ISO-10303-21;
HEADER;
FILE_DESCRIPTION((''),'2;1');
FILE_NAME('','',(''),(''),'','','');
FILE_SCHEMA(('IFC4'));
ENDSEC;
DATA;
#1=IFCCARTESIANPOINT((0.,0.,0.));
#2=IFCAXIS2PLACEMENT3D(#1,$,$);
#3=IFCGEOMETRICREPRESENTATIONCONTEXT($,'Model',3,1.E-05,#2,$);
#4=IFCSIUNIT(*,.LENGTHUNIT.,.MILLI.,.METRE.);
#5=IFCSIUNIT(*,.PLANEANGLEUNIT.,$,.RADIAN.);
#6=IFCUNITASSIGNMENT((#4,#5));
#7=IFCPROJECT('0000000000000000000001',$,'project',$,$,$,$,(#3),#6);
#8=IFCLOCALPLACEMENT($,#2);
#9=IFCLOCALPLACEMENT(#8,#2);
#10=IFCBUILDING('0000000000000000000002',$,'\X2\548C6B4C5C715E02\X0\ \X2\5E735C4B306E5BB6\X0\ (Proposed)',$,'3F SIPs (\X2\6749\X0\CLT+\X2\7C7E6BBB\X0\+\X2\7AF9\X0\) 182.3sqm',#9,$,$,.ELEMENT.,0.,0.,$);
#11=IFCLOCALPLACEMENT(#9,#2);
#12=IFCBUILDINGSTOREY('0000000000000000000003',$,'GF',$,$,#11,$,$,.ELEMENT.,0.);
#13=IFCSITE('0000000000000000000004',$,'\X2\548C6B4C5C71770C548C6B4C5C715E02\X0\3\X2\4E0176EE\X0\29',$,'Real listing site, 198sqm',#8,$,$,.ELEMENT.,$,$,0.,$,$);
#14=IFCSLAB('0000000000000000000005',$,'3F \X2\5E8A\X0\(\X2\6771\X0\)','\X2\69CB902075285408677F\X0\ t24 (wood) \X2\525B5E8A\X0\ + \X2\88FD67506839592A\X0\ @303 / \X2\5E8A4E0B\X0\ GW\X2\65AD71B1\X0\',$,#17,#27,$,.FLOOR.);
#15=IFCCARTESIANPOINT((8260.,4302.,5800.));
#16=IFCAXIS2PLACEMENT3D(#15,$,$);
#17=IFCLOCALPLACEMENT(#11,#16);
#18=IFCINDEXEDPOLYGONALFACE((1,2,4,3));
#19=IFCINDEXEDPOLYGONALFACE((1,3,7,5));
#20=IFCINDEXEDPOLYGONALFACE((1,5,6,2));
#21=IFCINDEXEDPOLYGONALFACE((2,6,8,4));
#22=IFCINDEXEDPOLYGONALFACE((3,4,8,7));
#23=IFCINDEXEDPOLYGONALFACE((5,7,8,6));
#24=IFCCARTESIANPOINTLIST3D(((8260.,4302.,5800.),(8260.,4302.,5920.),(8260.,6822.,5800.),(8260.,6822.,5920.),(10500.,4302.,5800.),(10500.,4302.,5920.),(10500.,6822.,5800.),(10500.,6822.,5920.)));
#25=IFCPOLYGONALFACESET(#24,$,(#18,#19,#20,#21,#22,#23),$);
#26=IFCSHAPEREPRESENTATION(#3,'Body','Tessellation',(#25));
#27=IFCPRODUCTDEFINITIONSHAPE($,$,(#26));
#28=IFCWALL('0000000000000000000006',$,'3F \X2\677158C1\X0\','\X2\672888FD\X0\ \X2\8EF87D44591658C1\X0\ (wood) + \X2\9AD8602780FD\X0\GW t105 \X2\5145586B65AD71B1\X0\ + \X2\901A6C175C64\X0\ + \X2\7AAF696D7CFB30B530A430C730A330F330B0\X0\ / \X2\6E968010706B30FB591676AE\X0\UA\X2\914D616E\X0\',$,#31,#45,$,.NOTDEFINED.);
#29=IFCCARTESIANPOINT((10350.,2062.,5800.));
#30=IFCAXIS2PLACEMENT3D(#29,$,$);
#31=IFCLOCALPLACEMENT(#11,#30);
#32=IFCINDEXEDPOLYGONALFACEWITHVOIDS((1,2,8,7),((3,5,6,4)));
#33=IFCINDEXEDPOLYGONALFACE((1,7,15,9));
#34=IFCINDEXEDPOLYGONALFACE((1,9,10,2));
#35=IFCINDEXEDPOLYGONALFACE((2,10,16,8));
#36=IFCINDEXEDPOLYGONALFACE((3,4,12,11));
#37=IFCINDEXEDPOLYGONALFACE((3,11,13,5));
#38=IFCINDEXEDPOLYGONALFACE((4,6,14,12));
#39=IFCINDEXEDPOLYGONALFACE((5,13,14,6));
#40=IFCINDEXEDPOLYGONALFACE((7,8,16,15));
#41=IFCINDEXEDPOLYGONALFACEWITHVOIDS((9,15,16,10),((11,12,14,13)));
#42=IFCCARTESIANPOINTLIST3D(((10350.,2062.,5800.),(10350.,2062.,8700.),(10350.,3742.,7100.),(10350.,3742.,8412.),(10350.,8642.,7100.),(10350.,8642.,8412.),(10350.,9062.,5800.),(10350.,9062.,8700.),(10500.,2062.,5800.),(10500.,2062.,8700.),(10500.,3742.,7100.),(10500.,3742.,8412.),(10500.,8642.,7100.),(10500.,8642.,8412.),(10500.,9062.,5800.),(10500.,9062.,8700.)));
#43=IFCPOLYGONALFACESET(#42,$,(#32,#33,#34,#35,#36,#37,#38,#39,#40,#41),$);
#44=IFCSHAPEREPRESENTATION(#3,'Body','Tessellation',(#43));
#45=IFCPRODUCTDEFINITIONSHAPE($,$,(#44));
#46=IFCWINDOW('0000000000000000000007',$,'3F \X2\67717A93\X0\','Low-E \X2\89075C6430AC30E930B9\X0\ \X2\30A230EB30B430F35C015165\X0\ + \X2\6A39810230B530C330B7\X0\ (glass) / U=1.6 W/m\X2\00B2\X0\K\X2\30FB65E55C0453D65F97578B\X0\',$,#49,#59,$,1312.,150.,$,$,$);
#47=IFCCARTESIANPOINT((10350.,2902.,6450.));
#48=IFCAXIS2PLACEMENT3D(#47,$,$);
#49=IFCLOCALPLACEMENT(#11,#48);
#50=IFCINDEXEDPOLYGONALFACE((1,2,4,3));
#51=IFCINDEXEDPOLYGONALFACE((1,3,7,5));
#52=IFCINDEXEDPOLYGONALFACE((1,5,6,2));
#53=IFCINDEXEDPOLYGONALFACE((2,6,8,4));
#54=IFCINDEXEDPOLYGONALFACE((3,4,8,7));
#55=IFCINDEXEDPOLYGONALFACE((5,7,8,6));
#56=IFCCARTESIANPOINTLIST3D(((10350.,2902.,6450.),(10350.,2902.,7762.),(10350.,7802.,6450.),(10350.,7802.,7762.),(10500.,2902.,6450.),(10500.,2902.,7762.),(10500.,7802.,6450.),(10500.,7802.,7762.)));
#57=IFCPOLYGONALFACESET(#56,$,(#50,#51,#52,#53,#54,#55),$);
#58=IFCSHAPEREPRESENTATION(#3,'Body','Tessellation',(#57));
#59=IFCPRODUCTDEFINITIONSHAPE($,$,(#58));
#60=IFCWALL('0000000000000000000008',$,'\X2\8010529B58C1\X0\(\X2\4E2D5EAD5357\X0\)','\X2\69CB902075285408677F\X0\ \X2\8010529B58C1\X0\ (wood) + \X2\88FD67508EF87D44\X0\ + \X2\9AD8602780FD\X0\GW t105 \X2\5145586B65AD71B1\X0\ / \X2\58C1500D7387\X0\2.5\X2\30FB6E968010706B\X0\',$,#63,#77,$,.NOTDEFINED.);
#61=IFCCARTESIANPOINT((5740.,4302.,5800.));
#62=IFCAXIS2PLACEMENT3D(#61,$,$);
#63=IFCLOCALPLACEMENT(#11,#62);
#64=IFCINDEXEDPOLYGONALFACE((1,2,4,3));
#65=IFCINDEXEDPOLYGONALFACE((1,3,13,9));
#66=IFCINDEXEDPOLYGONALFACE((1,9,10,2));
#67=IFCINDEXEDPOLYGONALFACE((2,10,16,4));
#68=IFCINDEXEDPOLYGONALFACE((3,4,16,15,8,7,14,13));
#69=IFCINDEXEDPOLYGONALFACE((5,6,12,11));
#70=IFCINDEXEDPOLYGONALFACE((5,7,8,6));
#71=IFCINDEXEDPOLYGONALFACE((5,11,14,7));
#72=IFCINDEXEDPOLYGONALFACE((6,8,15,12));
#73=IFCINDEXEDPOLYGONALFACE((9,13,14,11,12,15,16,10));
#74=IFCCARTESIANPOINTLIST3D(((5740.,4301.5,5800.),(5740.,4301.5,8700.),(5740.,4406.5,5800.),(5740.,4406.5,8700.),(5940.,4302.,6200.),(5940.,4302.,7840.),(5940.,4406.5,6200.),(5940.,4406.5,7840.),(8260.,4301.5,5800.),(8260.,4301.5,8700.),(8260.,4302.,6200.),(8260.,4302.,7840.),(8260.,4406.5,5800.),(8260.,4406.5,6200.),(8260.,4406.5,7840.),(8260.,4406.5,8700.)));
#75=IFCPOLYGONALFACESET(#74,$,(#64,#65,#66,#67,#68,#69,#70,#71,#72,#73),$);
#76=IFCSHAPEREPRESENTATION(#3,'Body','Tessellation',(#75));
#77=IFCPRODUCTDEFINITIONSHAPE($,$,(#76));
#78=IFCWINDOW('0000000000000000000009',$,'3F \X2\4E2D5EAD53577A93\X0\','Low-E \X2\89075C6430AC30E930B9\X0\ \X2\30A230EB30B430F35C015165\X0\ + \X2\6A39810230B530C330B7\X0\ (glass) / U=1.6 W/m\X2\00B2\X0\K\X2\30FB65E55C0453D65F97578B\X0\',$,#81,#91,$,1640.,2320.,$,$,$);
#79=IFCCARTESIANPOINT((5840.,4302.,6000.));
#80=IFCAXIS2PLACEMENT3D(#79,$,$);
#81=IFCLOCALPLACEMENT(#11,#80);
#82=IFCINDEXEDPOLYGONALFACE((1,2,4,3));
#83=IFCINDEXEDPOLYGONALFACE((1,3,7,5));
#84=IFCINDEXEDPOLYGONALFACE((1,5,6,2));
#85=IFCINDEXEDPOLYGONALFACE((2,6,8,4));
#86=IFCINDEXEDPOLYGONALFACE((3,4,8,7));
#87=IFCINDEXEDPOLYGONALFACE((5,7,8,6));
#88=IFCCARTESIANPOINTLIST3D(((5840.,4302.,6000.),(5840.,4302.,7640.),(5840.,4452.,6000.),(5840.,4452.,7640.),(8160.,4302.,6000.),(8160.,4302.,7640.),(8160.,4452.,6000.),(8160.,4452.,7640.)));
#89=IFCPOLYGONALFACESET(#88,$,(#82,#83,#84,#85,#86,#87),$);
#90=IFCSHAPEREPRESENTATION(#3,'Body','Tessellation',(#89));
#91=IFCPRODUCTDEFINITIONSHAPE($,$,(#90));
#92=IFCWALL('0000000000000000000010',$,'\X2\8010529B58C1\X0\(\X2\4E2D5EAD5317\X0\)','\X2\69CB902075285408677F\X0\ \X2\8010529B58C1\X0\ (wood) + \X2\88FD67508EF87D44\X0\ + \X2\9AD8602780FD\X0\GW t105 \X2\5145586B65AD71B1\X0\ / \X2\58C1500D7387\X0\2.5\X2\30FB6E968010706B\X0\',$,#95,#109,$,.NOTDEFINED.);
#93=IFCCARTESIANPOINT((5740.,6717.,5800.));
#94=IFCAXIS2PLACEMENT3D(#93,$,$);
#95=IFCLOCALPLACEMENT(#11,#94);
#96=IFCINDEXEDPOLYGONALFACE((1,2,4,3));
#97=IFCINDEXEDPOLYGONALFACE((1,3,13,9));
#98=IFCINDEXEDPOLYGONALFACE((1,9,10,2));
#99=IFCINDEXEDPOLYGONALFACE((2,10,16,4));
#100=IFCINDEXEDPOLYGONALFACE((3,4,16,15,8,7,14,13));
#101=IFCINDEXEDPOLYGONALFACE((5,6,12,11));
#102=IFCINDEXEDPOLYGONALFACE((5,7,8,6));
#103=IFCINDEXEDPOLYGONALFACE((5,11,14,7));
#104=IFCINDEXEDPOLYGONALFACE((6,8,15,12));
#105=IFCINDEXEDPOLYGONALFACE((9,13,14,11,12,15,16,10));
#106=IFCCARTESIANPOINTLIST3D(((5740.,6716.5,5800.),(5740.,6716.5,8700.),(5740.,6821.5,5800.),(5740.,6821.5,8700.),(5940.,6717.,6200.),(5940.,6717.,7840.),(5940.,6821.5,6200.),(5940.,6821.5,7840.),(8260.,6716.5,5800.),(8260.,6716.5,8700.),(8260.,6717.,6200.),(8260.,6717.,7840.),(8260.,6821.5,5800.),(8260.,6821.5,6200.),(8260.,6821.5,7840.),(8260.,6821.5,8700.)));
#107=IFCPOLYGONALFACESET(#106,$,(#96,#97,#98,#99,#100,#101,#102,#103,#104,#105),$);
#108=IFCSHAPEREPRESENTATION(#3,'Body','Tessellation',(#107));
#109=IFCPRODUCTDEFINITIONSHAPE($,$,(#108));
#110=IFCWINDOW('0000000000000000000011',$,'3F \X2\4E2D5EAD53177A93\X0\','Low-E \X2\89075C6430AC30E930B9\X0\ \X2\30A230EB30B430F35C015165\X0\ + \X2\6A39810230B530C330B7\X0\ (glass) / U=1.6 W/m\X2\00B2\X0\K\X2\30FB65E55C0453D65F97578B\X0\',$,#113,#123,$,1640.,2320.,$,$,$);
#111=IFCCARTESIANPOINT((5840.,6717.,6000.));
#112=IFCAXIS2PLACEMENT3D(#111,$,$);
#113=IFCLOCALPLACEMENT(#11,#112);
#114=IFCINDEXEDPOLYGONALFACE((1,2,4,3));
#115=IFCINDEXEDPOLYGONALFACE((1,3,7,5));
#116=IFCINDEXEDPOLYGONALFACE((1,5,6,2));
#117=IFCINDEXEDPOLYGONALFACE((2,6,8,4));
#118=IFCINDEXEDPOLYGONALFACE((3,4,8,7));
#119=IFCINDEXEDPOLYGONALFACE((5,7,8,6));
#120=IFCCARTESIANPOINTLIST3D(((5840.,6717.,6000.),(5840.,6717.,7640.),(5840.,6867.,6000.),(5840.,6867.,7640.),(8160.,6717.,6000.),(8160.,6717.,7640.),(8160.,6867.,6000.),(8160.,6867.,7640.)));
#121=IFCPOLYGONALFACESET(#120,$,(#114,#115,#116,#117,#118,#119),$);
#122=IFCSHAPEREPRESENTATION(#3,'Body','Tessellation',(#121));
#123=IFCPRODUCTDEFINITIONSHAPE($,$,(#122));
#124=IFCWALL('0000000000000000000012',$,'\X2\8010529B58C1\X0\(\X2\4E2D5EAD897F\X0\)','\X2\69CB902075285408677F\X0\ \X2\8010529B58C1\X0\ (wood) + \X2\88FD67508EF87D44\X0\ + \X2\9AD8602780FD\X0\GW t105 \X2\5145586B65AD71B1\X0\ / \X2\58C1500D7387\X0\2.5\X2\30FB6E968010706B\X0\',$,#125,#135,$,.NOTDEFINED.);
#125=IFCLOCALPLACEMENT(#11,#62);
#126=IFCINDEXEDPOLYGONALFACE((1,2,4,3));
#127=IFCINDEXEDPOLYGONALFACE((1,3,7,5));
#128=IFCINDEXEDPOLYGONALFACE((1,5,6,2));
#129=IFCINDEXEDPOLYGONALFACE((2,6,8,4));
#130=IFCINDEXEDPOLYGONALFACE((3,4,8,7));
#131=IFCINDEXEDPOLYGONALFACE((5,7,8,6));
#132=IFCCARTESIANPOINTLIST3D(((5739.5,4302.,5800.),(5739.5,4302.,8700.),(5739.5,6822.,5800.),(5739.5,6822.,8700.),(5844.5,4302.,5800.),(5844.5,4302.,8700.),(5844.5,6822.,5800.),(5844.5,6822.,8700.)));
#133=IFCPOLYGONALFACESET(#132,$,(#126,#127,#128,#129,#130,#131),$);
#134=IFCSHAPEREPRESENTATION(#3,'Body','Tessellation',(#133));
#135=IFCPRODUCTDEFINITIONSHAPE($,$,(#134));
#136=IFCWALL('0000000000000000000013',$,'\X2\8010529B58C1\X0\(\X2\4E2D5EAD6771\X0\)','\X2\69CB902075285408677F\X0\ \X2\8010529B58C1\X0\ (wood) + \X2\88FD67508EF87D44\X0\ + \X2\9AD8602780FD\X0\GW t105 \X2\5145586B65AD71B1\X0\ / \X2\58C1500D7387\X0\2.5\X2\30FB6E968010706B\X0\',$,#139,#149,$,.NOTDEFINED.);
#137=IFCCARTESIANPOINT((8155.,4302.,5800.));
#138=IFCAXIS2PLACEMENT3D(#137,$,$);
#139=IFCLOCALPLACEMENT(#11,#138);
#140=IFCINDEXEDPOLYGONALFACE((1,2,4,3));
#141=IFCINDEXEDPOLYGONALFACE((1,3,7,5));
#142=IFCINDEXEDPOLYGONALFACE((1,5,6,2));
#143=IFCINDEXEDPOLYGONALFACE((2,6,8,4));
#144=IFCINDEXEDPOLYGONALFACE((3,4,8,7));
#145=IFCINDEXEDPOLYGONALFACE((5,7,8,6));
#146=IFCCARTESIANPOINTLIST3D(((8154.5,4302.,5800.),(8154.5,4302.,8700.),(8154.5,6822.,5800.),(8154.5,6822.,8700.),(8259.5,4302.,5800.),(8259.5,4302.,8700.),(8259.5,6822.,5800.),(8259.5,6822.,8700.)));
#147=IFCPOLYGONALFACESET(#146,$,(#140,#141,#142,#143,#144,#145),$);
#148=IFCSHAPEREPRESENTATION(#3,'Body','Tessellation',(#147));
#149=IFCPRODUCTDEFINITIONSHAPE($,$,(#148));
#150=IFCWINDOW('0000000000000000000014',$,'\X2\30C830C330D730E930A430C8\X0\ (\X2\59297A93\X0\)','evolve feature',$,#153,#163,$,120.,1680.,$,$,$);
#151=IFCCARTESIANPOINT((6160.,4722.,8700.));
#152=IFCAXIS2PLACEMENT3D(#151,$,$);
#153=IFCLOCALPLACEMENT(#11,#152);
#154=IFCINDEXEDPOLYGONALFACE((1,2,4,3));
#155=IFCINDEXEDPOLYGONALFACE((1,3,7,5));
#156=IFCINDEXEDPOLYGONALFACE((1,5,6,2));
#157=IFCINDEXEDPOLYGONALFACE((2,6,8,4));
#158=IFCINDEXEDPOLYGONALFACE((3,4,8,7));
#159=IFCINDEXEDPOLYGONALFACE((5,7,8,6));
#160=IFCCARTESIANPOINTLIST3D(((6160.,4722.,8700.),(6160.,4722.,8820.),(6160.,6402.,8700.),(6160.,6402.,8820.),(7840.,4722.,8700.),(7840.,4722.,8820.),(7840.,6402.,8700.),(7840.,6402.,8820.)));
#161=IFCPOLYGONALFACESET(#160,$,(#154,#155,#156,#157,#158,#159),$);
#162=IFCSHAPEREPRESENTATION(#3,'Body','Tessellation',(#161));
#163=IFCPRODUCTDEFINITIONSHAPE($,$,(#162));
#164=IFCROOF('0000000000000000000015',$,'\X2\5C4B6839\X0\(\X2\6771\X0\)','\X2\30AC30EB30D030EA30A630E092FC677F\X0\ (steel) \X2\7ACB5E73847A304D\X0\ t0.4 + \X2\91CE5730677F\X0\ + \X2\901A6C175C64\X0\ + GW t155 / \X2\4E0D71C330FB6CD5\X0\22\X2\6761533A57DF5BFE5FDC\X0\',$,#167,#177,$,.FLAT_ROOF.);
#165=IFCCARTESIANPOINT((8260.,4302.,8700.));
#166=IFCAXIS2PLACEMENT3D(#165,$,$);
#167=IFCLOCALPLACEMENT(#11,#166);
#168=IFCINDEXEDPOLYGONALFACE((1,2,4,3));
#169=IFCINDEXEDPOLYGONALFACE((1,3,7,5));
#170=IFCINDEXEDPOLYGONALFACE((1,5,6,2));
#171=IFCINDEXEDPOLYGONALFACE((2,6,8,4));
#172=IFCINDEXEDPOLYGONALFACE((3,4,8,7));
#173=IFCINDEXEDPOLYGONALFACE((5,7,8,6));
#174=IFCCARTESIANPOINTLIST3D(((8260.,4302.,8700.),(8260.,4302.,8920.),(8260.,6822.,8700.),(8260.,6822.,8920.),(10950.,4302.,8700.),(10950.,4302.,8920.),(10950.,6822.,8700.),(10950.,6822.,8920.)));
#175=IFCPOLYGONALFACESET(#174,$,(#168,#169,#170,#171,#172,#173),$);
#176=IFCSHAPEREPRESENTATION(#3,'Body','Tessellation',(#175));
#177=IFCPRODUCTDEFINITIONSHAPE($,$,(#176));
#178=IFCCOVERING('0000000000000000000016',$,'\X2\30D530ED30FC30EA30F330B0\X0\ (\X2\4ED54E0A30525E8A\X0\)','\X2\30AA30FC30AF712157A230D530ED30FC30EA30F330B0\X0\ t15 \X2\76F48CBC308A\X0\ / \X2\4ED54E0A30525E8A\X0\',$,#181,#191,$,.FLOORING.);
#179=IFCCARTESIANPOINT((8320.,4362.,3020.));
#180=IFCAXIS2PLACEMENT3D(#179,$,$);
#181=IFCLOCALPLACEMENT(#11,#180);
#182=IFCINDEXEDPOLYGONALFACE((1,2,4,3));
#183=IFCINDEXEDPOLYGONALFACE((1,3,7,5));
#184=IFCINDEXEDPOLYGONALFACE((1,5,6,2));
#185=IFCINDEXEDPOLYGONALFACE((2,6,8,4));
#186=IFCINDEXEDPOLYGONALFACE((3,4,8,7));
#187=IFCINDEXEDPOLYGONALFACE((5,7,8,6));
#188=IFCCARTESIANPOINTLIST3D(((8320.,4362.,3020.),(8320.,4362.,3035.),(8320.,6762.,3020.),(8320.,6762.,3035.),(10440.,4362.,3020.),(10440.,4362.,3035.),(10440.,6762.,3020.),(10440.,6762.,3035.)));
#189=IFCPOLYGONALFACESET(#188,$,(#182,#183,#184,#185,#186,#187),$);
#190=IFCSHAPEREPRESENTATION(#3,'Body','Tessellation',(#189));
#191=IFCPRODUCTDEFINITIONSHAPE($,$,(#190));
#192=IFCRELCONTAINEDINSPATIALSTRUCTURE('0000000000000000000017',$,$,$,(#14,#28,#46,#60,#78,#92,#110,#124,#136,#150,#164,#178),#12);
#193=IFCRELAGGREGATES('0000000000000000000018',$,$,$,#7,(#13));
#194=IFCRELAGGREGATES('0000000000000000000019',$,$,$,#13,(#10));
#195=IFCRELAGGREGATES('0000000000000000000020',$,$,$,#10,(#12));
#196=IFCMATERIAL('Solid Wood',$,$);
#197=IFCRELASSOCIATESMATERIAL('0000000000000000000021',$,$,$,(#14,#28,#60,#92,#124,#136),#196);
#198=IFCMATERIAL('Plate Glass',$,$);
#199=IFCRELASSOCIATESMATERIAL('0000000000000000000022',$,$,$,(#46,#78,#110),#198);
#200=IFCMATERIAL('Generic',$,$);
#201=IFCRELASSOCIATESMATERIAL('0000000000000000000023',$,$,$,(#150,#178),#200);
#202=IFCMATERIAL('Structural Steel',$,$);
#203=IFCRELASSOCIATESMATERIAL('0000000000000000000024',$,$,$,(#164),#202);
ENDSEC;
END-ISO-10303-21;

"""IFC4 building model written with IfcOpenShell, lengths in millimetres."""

from ifc_helpers import new_model, si_unit, frame, frame_2d, origin, place, context, project, spatial, rectangle, extrude, material, element, fill, save


model = new_model("IFC4")

# Units and contexts
model_context = context("Model", 3, precision=1e-05, world=origin())
ifc_project = project(units=[si_unit("LENGTHUNIT", "METRE", prefix="MILLI"), si_unit("PLANEANGLEUNIT", "RADIAN")], contexts=[model_context])

# Site, building, storey
site_placement = place(None, origin())
site = spatial("IfcSite", under=ifc_project, at=site_placement, Name="和歌山県和歌山市3丁目29", ObjectType="Real listing site, 198sqm", CompositionType="ELEMENT", RefElevation=0.0)
building_placement = place(site_placement, origin())
building = spatial("IfcBuilding", under=site, at=building_placement, Name="和歌山市 平屋の家 (Proposed)", ObjectType="3F SIPs (杉CLT+籾殻+竹) 182.3sqm", CompositionType="ELEMENT", ElevationOfRefHeight=0.0, ElevationOfTerrain=0.0)
storey_placement = place(building_placement, origin())
storey = spatial("IfcBuildingStorey", under=building, at=storey_placement, Name="GF", CompositionType="ELEMENT", Elevation=0.0)

# Slab
ifc_material_1 = material(Name="Solid Wood")
slab_placement = place(storey_placement, frame((8260.0, 4302.0, 5800.0)))
element("IfcSlab", 1, at=slab_placement, inside=storey, material=ifc_material_1, Name="3F 床(東)", Description="構造用合板 t24 (wood) 剛床 + 製材根太 @303 / 床下 GW断熱", PredefinedType="FLOOR", context=model_context, shape_type="SweptSolid", body=[
    extrude(rectangle(XDim=2240.0, YDim=2520.0, at=frame_2d((1120.0, 1260.0))), frame((8260.0, 4302.0, 5800.0)), (0.0, 0.0, 1.0), 120.0),
])

# Walls, openings, windows
wall_1_placement = place(storey_placement, frame((10350.0, 2062.0, 5800.0)))
wall_1 = element("IfcWall", 2, at=wall_1_placement, inside=storey, material=ifc_material_1, Name="3F 東壁", Description="木製 軸組外壁 (wood) + 高性能GW t105 充填断熱 + 通気層 + 窯業系サイディング / 準耐火・外皮UA配慮", PredefinedType="NOTDEFINED", context=model_context, shape_type="SweptSolid", body=[
    extrude(rectangle(XDim=150.0, YDim=7000.0, at=frame_2d((75.0, 3500.0))), frame((10350.0, 2062.0, 5800.0)), (0.0, 0.0, 1.0), 2900.0),
])
opening_1_placement = place(storey_placement, frame((10350.0, 2902.0, 6450.0)))
opening_1 = element("IfcOpeningElement", 3, at=opening_1_placement, cuts=wall_1, PredefinedType="NOTDEFINED", context=model_context, shape_type="SweptSolid", body=[
    extrude(rectangle(XDim=150.0, YDim=4900.0, at=frame_2d((75.0, 2450.0))), frame((10350.0, 2902.0, 6450.0)), (0.0, 0.0, 1.0), 1312.0),
])
ifc_material_2 = material(Name="Plate Glass")
window_1_placement = place(storey_placement, frame((10350.0, 2902.0, 6450.0)))
window_1 = element("IfcWindow", 4, at=window_1_placement, inside=storey, material=ifc_material_2, Name="3F 東窓", Description="Low-E 複層ガラス アルゴン封入 + 樹脂サッシ (glass) / U=1.6 W/m²K・日射取得型", OverallHeight=1312.0, OverallWidth=150.0, context=model_context, shape_type="SweptSolid", body=[
    extrude(rectangle(XDim=150.0, YDim=4900.0, at=frame_2d((75.0, 2450.0))), frame((10350.0, 2902.0, 6450.0)), (0.0, 0.0, 1.0), 1312.0),
])
fill(opening_1, window_1)
wall_2_placement = place(storey_placement, frame((5740.0, 4302.0, 5800.0)))
wall_2 = element("IfcWall", 5, at=wall_2_placement, inside=storey, material=ifc_material_1, Name="耐力壁(中庭南)", Description="構造用合板 耐力壁 (wood) + 製材軸組 + 高性能GW t105 充填断熱 / 壁倍率2.5・準耐火", PredefinedType="NOTDEFINED", context=model_context, shape_type="SweptSolid", body=[
    extrude(rectangle(XDim=2520.0, YDim=105.0, at=frame_2d((1260.0, 52.0))), frame((5740.0, 4302.0, 5800.0)), (0.0, 0.0, 1.0), 2900.0),
])
opening_2_placement = place(storey_placement, frame((5840.0, 4302.0, 6000.0)))
opening_2 = element("IfcOpeningElement", 6, at=opening_2_placement, cuts=wall_2, PredefinedType="NOTDEFINED", context=model_context, shape_type="SweptSolid", body=[
    extrude(rectangle(XDim=2320.0, YDim=150.0, at=frame_2d((1160.0, 75.0))), frame((5840.0, 4302.0, 6000.0)), (0.0, 0.0, 1.0), 1640.0),
])
window_2_placement = place(storey_placement, frame((5840.0, 4302.0, 6000.0)))
window_2 = element("IfcWindow", 7, at=window_2_placement, inside=storey, material=ifc_material_2, Name="3F 中庭南窓", Description="Low-E 複層ガラス アルゴン封入 + 樹脂サッシ (glass) / U=1.6 W/m²K・日射取得型", OverallHeight=1640.0, OverallWidth=2320.0, context=model_context, shape_type="SweptSolid", body=[
    extrude(rectangle(XDim=2320.0, YDim=150.0, at=frame_2d((1160.0, 75.0))), frame((5840.0, 4302.0, 6000.0)), (0.0, 0.0, 1.0), 1640.0),
])
fill(opening_2, window_2)
wall_3_placement = place(storey_placement, frame((5740.0, 6717.0, 5800.0)))
wall_3 = element("IfcWall", 8, at=wall_3_placement, inside=storey, material=ifc_material_1, Name="耐力壁(中庭北)", Description="構造用合板 耐力壁 (wood) + 製材軸組 + 高性能GW t105 充填断熱 / 壁倍率2.5・準耐火", PredefinedType="NOTDEFINED", context=model_context, shape_type="SweptSolid", body=[
    extrude(rectangle(XDim=2520.0, YDim=105.0, at=frame_2d((1260.0, 52.0))), frame((5740.0, 6717.0, 5800.0)), (0.0, 0.0, 1.0), 2900.0),
])
opening_3_placement = place(storey_placement, frame((5840.0, 6717.0, 6000.0)))
opening_3 = element("IfcOpeningElement", 9, at=opening_3_placement, cuts=wall_3, PredefinedType="NOTDEFINED", context=model_context, shape_type="SweptSolid", body=[
    extrude(rectangle(XDim=2320.0, YDim=150.0, at=frame_2d((1160.0, 75.0))), frame((5840.0, 6717.0, 6000.0)), (0.0, 0.0, 1.0), 1640.0),
])
window_3_placement = place(storey_placement, frame((5840.0, 6717.0, 6000.0)))
window_3 = element("IfcWindow", 10, at=window_3_placement, inside=storey, material=ifc_material_2, Name="3F 中庭北窓", Description="Low-E 複層ガラス アルゴン封入 + 樹脂サッシ (glass) / U=1.6 W/m²K・日射取得型", OverallHeight=1640.0, OverallWidth=2320.0, context=model_context, shape_type="SweptSolid", body=[
    extrude(rectangle(XDim=2320.0, YDim=150.0, at=frame_2d((1160.0, 75.0))), frame((5840.0, 6717.0, 6000.0)), (0.0, 0.0, 1.0), 1640.0),
])
fill(opening_3, window_3)

# Walls
wall_4_placement = place(storey_placement, frame((5740.0, 4302.0, 5800.0)))
element("IfcWall", 11, at=wall_4_placement, inside=storey, material=ifc_material_1, Name="耐力壁(中庭西)", Description="構造用合板 耐力壁 (wood) + 製材軸組 + 高性能GW t105 充填断熱 / 壁倍率2.5・準耐火", PredefinedType="NOTDEFINED", context=model_context, shape_type="SweptSolid", body=[
    extrude(rectangle(XDim=105.0, YDim=2520.0, at=frame_2d((52.0, 1260.0))), frame((5740.0, 4302.0, 5800.0)), (0.0, 0.0, 1.0), 2900.0),
])
wall_5_placement = place(storey_placement, frame((8155.0, 4302.0, 5800.0)))
element("IfcWall", 12, at=wall_5_placement, inside=storey, material=ifc_material_1, Name="耐力壁(中庭東)", Description="構造用合板 耐力壁 (wood) + 製材軸組 + 高性能GW t105 充填断熱 / 壁倍率2.5・準耐火", PredefinedType="NOTDEFINED", context=model_context, shape_type="SweptSolid", body=[
    extrude(rectangle(XDim=105.0, YDim=2520.0, at=frame_2d((52.0, 1260.0))), frame((8155.0, 4302.0, 5800.0)), (0.0, 0.0, 1.0), 2900.0),
])

# Window
ifc_material_3 = material(Name="Generic")
window_4_placement = place(storey_placement, frame((6160.0, 4722.0, 8700.0)))
element("IfcWindow", 13, at=window_4_placement, inside=storey, material=ifc_material_3, Name="トップライト (天窓)", Description="evolve feature", OverallHeight=120.0, OverallWidth=1680.0, context=model_context, shape_type="SweptSolid", body=[
    extrude(rectangle(XDim=1680.0, YDim=1680.0, at=frame_2d((840.0, 840.0))), frame((6160.0, 4722.0, 8700.0)), (0.0, 0.0, 1.0), 120.0),
])

# Roof
ifc_material_4 = material(Name="Structural Steel")
for number, where, name in (
    (14, (8260.0, 4302.0, 8700.0), "屋根(東)"),
):
    element("IfcRoof", number, at=place(storey_placement, frame(where)), inside=storey, material=ifc_material_4, Name=name, Description="ガルバリウム鋼板 (steel) 立平葺き t0.4 + 野地板 + 通気層 + GW t155 / 不燃・法22条区域対応", PredefinedType="FLAT_ROOF", context=model_context, shape_type="SweptSolid", body=[
        extrude(rectangle(XDim=2690.0, YDim=2520.0, at=frame_2d((1345.0, 1260.0))), frame((8260.0, 4302.0, 8700.0)), (0.0, 0.0, 1.0), 220.0),
    ])

# Covering
covering_1_placement = place(storey_placement, frame((8320.0, 4362.0, 3020.0)))
element("IfcCovering", 15, at=covering_1_placement, inside=storey, material=ifc_material_3, Name="フローリング (仕上げ床)", Description="オーク無垢フローリング t15 直貼り / 仕上げ床", PredefinedType="FLOORING", context=model_context, shape_type="SweptSolid", body=[
    extrude(rectangle(XDim=2120.0, YDim=2400.0, at=frame_2d((1060.0, 1200.0))), frame((8320.0, 4362.0, 3020.0)), (0.0, 0.0, 1.0), 15.0),
])

save(model, "model.ifc")
